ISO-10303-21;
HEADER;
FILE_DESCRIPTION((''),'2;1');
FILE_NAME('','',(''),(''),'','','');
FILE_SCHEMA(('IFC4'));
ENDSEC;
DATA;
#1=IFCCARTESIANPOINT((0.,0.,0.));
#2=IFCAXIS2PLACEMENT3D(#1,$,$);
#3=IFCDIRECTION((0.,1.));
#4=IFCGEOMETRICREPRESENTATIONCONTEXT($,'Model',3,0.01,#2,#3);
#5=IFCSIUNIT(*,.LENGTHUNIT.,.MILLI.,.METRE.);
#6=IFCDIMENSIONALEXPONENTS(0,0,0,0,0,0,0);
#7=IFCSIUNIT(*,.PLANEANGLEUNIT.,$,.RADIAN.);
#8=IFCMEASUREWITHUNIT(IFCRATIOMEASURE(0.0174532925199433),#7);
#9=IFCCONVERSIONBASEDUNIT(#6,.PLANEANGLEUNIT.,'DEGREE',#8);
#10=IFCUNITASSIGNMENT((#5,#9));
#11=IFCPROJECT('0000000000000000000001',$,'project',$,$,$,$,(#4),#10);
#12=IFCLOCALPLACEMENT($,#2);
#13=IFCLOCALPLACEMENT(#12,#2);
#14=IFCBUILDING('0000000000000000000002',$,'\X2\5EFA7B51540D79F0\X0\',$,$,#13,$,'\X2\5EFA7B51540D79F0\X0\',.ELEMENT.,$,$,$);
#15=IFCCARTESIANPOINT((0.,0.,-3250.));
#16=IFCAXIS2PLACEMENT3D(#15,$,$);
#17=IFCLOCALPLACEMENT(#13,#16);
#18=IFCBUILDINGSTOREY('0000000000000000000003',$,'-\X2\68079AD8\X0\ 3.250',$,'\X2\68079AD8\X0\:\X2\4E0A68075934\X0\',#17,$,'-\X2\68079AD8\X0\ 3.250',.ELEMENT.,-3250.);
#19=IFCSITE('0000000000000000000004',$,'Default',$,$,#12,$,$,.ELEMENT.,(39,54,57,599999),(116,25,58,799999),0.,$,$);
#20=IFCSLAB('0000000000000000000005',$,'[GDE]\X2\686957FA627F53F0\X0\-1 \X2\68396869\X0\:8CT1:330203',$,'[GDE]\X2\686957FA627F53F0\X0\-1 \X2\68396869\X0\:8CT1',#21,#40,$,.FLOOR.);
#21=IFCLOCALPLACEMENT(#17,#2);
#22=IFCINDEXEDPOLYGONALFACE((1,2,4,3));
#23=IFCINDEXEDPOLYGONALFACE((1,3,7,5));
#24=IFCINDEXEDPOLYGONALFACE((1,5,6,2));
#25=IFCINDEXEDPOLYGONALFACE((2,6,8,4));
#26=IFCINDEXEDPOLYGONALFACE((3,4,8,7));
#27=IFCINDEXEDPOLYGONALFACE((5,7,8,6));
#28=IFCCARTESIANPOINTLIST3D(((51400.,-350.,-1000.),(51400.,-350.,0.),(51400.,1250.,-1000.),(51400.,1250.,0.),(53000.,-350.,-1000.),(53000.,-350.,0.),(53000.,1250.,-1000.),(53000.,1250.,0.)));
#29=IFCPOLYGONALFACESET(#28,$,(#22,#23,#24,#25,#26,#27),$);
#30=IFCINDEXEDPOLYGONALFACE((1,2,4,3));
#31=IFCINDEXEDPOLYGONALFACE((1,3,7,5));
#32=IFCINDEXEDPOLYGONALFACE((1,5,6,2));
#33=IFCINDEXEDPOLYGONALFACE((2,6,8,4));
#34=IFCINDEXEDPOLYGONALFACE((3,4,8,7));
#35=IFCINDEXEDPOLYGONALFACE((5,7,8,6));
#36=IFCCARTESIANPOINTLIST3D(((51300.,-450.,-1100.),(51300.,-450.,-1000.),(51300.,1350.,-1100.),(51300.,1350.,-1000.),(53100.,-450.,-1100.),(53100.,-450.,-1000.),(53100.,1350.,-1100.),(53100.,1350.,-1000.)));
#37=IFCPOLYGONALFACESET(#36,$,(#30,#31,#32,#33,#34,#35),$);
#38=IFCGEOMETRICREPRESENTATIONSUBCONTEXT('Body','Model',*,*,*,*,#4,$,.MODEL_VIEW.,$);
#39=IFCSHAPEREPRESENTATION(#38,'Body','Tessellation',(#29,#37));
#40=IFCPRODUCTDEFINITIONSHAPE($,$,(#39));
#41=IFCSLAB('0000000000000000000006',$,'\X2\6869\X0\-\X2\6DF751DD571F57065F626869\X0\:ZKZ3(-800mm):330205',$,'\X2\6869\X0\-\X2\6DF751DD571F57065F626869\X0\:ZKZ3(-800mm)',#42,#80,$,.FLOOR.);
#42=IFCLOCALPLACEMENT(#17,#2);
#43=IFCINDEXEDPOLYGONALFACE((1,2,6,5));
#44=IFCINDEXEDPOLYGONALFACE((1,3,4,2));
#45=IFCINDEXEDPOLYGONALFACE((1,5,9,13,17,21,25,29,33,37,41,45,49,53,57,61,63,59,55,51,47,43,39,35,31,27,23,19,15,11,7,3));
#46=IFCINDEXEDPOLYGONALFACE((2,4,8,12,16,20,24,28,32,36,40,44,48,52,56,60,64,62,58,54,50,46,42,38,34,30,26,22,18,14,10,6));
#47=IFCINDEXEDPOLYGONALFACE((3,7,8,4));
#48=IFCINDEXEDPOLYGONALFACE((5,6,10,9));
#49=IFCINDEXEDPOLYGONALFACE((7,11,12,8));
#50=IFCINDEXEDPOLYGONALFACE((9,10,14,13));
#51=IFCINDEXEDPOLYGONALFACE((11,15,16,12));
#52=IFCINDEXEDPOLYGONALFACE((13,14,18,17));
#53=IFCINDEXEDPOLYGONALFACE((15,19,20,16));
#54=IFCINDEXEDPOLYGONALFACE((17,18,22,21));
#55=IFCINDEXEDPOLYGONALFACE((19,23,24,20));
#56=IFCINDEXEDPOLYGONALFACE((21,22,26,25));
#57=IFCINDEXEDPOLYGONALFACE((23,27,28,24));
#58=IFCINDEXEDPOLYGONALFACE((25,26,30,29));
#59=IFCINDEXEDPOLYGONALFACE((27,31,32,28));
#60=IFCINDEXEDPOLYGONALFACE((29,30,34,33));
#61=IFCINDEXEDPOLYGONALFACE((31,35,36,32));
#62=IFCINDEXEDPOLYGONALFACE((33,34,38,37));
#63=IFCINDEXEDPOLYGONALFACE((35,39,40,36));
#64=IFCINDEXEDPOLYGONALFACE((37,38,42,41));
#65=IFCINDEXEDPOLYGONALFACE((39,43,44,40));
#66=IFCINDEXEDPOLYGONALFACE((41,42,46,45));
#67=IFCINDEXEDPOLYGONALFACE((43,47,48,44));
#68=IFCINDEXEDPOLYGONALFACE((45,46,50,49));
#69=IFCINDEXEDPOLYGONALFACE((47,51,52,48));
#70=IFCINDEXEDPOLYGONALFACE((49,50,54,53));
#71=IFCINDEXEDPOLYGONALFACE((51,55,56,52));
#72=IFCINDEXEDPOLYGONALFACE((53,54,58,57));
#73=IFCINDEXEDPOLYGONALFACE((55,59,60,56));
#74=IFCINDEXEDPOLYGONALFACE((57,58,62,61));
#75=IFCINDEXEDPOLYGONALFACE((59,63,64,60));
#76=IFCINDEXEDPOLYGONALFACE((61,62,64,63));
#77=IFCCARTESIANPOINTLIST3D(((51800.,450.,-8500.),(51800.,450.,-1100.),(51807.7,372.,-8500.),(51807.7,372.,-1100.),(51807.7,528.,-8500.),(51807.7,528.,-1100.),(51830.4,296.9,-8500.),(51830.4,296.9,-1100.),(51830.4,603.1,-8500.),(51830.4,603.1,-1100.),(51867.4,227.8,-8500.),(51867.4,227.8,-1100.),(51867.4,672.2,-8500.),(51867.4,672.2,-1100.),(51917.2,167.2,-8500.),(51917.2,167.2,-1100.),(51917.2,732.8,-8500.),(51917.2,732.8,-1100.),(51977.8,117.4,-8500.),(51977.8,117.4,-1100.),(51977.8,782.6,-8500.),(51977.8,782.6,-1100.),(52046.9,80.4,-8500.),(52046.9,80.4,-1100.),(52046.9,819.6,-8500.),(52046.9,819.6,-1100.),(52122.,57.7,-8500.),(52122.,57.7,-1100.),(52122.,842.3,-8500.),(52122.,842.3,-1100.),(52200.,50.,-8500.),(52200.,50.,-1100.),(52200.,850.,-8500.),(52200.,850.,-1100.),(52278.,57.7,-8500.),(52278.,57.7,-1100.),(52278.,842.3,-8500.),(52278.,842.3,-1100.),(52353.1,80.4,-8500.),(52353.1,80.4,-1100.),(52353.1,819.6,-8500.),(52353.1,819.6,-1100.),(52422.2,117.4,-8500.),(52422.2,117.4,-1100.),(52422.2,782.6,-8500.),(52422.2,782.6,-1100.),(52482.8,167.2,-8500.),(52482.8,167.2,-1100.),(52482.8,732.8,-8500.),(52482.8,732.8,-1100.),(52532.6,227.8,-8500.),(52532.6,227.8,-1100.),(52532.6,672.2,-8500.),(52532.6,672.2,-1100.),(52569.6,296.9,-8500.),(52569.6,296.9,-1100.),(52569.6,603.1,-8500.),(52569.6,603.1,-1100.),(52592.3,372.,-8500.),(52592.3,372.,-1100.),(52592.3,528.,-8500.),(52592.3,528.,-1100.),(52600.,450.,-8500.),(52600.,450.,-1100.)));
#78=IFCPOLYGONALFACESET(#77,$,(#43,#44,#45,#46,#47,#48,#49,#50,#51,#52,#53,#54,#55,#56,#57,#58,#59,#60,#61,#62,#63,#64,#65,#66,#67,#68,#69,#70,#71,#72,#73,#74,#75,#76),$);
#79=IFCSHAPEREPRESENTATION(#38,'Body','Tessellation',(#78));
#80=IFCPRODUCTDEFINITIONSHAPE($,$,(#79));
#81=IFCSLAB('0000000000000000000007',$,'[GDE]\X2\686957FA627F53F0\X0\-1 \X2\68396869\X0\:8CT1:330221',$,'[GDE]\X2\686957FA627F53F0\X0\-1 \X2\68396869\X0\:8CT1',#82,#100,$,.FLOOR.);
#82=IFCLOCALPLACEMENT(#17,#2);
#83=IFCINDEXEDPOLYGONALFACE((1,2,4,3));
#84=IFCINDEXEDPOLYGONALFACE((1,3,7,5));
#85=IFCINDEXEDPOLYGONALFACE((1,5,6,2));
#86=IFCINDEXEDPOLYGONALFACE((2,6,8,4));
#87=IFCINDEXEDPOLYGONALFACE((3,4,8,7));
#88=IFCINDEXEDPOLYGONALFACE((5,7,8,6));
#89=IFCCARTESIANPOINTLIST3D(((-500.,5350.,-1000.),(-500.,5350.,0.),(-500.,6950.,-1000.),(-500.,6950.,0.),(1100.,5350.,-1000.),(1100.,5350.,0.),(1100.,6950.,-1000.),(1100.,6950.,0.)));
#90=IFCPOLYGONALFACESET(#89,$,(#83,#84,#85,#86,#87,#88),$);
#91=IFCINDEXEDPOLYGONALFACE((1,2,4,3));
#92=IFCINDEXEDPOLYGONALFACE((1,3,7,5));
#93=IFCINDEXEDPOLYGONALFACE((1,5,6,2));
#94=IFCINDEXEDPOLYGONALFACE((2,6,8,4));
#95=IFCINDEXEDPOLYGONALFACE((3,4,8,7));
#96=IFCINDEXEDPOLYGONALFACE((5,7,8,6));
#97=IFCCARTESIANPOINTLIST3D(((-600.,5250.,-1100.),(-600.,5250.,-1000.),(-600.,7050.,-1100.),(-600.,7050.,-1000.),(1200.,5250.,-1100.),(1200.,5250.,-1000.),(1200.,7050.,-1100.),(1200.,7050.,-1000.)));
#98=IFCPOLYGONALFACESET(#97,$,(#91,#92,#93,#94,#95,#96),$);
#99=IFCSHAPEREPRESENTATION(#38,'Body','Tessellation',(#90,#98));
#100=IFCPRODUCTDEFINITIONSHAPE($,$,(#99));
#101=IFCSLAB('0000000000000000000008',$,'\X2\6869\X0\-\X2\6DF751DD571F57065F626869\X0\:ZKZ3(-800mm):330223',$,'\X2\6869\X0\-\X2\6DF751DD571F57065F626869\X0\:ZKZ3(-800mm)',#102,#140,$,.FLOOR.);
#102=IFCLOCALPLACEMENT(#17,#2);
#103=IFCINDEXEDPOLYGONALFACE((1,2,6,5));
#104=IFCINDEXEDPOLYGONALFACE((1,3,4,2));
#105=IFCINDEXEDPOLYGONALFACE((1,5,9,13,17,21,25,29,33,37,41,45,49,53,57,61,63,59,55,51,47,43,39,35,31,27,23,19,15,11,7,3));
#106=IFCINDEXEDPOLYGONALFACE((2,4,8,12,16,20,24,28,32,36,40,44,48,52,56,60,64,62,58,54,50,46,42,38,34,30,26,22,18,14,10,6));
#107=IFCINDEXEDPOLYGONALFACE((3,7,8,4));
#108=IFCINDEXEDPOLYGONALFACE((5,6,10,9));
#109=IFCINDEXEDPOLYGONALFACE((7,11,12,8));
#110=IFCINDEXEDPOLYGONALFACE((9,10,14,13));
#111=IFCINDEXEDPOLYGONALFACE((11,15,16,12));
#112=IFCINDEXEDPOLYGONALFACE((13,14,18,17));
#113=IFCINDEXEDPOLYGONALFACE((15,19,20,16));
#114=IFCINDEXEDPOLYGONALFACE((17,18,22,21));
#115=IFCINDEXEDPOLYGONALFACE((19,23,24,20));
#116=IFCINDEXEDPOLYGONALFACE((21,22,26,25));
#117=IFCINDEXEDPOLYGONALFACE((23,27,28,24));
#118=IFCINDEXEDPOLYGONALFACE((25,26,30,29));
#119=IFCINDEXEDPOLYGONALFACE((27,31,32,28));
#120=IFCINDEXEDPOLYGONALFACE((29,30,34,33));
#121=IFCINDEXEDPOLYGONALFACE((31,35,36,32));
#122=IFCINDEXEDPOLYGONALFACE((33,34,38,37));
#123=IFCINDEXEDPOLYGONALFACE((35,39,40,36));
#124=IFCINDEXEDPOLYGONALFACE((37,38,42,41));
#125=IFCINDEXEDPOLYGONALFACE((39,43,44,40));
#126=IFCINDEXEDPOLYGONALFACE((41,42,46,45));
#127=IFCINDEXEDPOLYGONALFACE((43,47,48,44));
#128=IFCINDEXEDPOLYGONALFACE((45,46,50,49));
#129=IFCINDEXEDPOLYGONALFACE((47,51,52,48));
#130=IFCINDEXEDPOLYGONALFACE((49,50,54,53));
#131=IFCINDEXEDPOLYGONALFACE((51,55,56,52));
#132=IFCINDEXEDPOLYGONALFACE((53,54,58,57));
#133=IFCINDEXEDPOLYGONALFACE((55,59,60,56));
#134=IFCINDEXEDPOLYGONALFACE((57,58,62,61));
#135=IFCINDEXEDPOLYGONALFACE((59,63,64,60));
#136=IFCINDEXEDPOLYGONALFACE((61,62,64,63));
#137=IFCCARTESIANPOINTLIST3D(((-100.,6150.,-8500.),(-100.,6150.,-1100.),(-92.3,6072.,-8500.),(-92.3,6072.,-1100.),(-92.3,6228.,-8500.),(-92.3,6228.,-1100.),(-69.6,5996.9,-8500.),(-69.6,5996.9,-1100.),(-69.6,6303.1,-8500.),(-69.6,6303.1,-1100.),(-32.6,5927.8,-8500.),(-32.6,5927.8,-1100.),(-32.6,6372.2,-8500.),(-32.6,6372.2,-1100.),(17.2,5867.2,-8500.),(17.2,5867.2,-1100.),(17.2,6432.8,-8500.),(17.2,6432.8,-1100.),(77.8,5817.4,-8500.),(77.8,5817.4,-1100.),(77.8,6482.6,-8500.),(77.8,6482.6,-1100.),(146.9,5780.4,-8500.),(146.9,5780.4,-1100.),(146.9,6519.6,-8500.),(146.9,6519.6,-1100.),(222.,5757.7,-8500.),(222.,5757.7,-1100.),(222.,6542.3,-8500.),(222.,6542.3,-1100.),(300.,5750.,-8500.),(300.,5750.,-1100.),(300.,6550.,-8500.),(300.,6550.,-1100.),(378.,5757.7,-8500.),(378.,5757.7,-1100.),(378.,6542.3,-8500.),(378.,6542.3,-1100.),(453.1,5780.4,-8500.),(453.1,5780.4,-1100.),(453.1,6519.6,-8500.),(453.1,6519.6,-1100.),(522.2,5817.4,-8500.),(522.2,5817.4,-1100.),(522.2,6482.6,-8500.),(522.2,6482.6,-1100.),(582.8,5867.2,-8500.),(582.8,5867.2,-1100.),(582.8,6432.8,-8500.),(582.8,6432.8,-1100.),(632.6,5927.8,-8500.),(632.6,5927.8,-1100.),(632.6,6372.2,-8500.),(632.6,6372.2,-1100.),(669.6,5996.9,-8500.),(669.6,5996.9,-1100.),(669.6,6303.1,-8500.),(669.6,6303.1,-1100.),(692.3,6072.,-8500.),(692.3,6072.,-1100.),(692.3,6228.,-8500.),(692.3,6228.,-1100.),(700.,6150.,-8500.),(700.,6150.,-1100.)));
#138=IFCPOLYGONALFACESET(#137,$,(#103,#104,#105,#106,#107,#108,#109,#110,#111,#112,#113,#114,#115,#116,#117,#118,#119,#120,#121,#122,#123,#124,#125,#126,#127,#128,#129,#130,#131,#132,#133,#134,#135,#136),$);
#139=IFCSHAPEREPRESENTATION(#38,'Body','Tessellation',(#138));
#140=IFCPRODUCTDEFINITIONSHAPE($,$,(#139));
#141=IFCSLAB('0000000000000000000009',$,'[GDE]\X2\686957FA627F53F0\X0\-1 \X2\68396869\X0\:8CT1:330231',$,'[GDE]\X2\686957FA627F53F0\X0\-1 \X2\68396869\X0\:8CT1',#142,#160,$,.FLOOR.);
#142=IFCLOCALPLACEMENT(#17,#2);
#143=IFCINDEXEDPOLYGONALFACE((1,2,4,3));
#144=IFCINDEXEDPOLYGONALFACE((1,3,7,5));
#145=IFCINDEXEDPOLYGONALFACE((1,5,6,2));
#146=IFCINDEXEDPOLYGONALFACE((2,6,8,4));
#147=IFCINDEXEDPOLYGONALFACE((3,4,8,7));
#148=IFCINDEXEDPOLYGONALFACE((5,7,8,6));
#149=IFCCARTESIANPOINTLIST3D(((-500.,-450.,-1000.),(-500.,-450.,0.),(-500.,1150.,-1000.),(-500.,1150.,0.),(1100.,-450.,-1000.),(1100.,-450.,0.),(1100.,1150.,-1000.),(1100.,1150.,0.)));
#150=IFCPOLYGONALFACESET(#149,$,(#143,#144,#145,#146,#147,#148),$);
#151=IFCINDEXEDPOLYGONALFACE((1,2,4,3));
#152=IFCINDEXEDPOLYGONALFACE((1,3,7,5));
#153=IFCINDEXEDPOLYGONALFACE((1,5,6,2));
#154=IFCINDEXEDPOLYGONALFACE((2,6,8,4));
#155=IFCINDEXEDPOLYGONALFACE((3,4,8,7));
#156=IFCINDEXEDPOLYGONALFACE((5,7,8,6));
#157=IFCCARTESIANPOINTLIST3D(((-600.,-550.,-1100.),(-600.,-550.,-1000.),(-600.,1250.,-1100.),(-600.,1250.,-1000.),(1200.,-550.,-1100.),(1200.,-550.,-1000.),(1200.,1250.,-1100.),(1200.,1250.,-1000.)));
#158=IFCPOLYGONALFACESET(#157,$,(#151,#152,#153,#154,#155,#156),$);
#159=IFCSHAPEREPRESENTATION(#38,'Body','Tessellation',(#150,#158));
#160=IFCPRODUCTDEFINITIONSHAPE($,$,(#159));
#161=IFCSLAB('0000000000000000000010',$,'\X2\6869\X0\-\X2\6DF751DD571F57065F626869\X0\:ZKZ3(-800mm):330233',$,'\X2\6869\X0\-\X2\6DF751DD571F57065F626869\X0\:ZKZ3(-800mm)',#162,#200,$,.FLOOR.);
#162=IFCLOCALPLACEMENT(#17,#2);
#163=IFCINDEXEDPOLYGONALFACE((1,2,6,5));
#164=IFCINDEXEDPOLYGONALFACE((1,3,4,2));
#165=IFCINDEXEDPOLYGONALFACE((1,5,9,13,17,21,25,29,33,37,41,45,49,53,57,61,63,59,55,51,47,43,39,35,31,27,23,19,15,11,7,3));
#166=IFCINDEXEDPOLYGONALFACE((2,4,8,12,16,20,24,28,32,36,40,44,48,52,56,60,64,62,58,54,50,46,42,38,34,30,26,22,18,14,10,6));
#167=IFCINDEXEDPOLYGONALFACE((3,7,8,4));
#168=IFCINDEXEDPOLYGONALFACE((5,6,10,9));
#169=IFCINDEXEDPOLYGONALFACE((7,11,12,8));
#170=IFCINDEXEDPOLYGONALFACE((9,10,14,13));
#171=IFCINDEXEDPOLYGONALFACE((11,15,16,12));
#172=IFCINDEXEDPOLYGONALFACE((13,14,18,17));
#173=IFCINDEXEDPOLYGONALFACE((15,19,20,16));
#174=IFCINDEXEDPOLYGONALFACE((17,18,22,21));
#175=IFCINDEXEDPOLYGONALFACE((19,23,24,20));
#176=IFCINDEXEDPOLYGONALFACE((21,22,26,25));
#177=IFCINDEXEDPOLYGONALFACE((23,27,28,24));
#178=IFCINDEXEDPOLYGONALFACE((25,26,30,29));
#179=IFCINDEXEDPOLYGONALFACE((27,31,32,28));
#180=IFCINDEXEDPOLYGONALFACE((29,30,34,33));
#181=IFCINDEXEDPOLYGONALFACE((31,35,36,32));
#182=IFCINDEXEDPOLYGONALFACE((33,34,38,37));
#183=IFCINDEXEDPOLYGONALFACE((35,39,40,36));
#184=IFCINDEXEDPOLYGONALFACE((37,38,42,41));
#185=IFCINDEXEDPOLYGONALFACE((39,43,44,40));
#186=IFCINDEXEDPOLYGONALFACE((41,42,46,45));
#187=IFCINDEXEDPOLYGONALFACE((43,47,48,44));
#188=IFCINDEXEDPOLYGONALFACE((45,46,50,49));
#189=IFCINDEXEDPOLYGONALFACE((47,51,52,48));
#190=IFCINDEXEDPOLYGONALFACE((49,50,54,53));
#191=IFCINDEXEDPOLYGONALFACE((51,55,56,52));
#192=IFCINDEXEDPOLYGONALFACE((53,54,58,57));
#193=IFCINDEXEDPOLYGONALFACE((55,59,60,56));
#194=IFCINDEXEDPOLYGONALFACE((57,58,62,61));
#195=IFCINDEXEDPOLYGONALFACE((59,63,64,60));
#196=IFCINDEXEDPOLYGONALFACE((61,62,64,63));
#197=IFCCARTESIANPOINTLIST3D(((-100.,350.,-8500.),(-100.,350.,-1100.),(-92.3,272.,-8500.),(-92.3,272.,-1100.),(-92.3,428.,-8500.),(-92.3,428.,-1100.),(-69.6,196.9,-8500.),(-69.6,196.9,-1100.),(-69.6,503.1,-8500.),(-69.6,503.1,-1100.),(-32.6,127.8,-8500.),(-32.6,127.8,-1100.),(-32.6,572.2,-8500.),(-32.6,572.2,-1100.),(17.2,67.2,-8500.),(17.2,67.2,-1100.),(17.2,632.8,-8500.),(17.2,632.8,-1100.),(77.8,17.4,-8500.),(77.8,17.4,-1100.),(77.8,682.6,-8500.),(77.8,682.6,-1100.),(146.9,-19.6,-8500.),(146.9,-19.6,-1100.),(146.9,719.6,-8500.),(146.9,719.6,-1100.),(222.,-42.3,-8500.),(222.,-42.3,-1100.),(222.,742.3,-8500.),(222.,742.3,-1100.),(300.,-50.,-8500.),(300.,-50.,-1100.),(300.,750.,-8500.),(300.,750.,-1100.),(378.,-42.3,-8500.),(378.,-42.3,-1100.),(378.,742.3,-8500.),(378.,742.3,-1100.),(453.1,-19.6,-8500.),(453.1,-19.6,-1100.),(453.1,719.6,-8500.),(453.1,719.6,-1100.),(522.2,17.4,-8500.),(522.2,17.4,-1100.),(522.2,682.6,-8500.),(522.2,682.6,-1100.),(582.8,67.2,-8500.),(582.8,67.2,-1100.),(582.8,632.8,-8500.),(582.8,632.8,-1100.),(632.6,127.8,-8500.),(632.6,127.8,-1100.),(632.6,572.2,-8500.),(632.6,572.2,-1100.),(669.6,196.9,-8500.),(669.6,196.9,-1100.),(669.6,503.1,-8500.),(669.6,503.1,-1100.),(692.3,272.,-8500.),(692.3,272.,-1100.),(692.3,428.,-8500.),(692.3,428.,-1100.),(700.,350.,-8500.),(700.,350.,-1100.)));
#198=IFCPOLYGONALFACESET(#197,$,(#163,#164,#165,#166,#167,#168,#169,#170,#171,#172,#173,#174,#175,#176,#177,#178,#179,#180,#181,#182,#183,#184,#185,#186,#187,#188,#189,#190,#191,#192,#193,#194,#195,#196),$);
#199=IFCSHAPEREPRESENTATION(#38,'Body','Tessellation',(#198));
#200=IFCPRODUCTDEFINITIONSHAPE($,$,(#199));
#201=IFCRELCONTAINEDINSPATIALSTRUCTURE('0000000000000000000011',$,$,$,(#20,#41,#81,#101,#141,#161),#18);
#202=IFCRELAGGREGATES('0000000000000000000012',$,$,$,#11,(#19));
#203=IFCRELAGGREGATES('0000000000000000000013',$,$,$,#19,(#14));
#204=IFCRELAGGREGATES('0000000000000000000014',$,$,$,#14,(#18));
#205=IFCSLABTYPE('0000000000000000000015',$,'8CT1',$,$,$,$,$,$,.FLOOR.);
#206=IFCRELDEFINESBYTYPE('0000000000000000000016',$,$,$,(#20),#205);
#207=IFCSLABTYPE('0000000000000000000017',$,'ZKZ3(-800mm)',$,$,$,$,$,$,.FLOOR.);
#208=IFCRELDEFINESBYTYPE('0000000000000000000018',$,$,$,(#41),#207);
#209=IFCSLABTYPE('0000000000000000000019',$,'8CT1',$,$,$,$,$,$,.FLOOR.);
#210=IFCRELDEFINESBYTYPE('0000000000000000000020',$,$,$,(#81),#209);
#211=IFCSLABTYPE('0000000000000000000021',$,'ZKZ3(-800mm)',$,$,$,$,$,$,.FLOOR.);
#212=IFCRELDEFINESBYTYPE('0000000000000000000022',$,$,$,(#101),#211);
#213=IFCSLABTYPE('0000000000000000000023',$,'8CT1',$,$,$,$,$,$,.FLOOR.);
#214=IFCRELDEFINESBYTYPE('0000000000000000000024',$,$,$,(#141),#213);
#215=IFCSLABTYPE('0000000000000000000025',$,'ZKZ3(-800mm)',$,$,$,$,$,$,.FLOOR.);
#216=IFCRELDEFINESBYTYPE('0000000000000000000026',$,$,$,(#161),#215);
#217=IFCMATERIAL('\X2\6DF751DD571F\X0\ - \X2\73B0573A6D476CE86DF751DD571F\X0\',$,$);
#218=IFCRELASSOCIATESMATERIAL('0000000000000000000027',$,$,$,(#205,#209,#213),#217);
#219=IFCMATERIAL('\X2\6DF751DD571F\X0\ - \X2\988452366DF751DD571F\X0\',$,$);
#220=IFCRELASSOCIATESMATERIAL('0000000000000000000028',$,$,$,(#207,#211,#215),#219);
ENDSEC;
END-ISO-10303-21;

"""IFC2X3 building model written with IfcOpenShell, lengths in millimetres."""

from ifc_helpers import new_model, entity, si_unit, converted_unit, direction, frame, frame_2d, origin, origin_2d_with_axis, place, context, subcontext, project, spatial, rectangle, circle, extrude, material, type_object, element, save


model = new_model("IFC2X3")

# Units and contexts
model_context = context("Model", 3, precision=0.01, world=origin(), true_north=direction((0.0, 1.0)))
body_context = subcontext(model_context, "Body", "Model", "MODEL_VIEW")
ifc_project = project(units=[si_unit("LENGTHUNIT", "METRE", prefix="MILLI"), converted_unit("PLANEANGLEUNIT", "DEGREE", entity("IfcRatioMeasure", 0.0174532925199433), si_unit("PLANEANGLEUNIT", "RADIAN"), dimensions=[0, 0, 0, 0, 0, 0, 0])], contexts=[model_context])

# Site, building, storey
site_placement = place(None, origin())
site = spatial("IfcSite", under=ifc_project, at=site_placement, Name="Default", CompositionType="ELEMENT", RefLatitude=(39, 54, 57, 599999), RefLongitude=(116, 25, 58, 799999), RefElevation=0.0)
building_placement = place(site_placement, origin())
building = spatial("IfcBuilding", under=site, at=building_placement, Name="建筑名称", LongName="建筑名称", CompositionType="ELEMENT")
storey_placement = place(building_placement, frame((0.0, 0.0, -3250.0)))
storey = spatial("IfcBuildingStorey", under=building, at=storey_placement, Name="-标高 3.250", ObjectType="标高:上标头", LongName="-标高 3.250", CompositionType="ELEMENT", Elevation=-3250.0)

# Slabs
ifc_material_1 = material(Name="混凝土 - 现场浇注混凝土")
ifc_material_2 = material(Name="混凝土 - 预制混凝土")
slab_type_1 = type_object("IfcSlabType", Name="8CT1", PredefinedType="FLOOR", material=ifc_material_1)
slab_1_placement = place(storey_placement, origin())
element("IfcSlab", 1, at=slab_1_placement, inside=storey, type_object=slab_type_1, Name="[GDE]桩基承台-1 根桩:8CT1:330203", ObjectType="[GDE]桩基承台-1 根桩:8CT1", PredefinedType="FLOOR", context=body_context, shape_type="SweptSolid", body=[
    extrude(rectangle(XDim=1600.0, YDim=1600.0, at=origin_2d_with_axis()), frame((52200.0, 450.0, -1000.0), z_axis=(0.0, 0.0, 1.0), x_axis=(-1.0, 0.0, 0.0)), (0.0, 0.0, 1.0), 1000.0),
    extrude(rectangle(XDim=1800.0, YDim=1800.0, at=frame_2d((0.0, 0.0), x_axis=(1.0, 0.0))), frame((52200.0, 450.0, -1100.0), z_axis=(0.0, 0.0, 1.0), x_axis=(-1.0, 0.0, 0.0)), (0.0, 0.0, 1.0), 100.0),
])
slab_type_2 = type_object("IfcSlabType", Name="ZKZ3(-800mm)", PredefinedType="FLOOR", material=ifc_material_2)
slab_2_placement = place(storey_placement, origin())
element("IfcSlab", 2, at=slab_2_placement, inside=storey, type_object=slab_type_2, Name="桩-混凝土圆形桩:ZKZ3(-800mm):330205", ObjectType="桩-混凝土圆形桩:ZKZ3(-800mm)", PredefinedType="FLOOR", context=body_context, shape_type="SweptSolid", body=[
    extrude(circle(Radius=400.0, at=frame_2d((0.0, 0.0), x_axis=(1.0, 0.0))), frame((52200.0, 450.0, -8500.0)), (0.0, 0.0, 1.0), 7400.0),
])
slab_type_3 = type_object("IfcSlabType", Name="8CT1", PredefinedType="FLOOR", material=ifc_material_1)
slab_3_placement = place(storey_placement, origin())
element("IfcSlab", 3, at=slab_3_placement, inside=storey, type_object=slab_type_3, Name="[GDE]桩基承台-1 根桩:8CT1:330221", ObjectType="[GDE]桩基承台-1 根桩:8CT1", PredefinedType="FLOOR", context=body_context, shape_type="SweptSolid", body=[
    extrude(rectangle(XDim=1600.0, YDim=1600.0, at=origin_2d_with_axis()), frame((300.0, 6150.0, -1000.0), z_axis=(0.0, 0.0, 1.0), x_axis=(-1.0, 0.0, 0.0)), (0.0, 0.0, 1.0), 1000.0),
    extrude(rectangle(XDim=1800.0, YDim=1800.0, at=origin_2d_with_axis()), frame((300.0, 6150.0, -1100.0), z_axis=(0.0, 0.0, 1.0), x_axis=(-1.0, 0.0, 0.0)), (0.0, 0.0, 1.0), 100.0),
])
slab_type_4 = type_object("IfcSlabType", Name="ZKZ3(-800mm)", PredefinedType="FLOOR", material=ifc_material_2)
slab_4_placement = place(storey_placement, origin())
element("IfcSlab", 4, at=slab_4_placement, inside=storey, type_object=slab_type_4, Name="桩-混凝土圆形桩:ZKZ3(-800mm):330223", ObjectType="桩-混凝土圆形桩:ZKZ3(-800mm)", PredefinedType="FLOOR", context=body_context, shape_type="SweptSolid", body=[
    extrude(circle(Radius=400.0, at=frame_2d((0.0, 0.0), x_axis=(1.0, 0.0))), frame((300.0, 6150.0, -8500.0)), (0.0, 0.0, 1.0), 7400.0),
])
slab_type_5 = type_object("IfcSlabType", Name="8CT1", PredefinedType="FLOOR", material=ifc_material_1)
slab_5_placement = place(storey_placement, origin())
element("IfcSlab", 5, at=slab_5_placement, inside=storey, type_object=slab_type_5, Name="[GDE]桩基承台-1 根桩:8CT1:330231", ObjectType="[GDE]桩基承台-1 根桩:8CT1", PredefinedType="FLOOR", context=body_context, shape_type="SweptSolid", body=[
    extrude(rectangle(XDim=1600.0, YDim=1600.0, at=origin_2d_with_axis()), frame((300.0, 350.0, -1000.0), z_axis=(0.0, 0.0, 1.0), x_axis=(-1.0, 0.0, 0.0)), (0.0, 0.0, 1.0), 1000.0),
    extrude(rectangle(XDim=1800.0, YDim=1800.0, at=origin_2d_with_axis()), frame((300.0, 350.0, -1100.0), z_axis=(0.0, 0.0, 1.0), x_axis=(-1.0, 0.0, 0.0)), (0.0, 0.0, 1.0), 100.0),
])
slab_type_6 = type_object("IfcSlabType", Name="ZKZ3(-800mm)", PredefinedType="FLOOR", material=ifc_material_2)
slab_6_placement = place(storey_placement, origin())
element("IfcSlab", 6, at=slab_6_placement, inside=storey, type_object=slab_type_6, Name="桩-混凝土圆形桩:ZKZ3(-800mm):330233", ObjectType="桩-混凝土圆形桩:ZKZ3(-800mm)", PredefinedType="FLOOR", context=body_context, shape_type="SweptSolid", body=[
    extrude(circle(Radius=400.0, at=frame_2d((0.0, 0.0), x_axis=(1.0, 0.0))), frame((300.0, 350.0, -8500.0)), (0.0, 0.0, 1.0), 7400.0),
])

save(model, "model.ifc")
